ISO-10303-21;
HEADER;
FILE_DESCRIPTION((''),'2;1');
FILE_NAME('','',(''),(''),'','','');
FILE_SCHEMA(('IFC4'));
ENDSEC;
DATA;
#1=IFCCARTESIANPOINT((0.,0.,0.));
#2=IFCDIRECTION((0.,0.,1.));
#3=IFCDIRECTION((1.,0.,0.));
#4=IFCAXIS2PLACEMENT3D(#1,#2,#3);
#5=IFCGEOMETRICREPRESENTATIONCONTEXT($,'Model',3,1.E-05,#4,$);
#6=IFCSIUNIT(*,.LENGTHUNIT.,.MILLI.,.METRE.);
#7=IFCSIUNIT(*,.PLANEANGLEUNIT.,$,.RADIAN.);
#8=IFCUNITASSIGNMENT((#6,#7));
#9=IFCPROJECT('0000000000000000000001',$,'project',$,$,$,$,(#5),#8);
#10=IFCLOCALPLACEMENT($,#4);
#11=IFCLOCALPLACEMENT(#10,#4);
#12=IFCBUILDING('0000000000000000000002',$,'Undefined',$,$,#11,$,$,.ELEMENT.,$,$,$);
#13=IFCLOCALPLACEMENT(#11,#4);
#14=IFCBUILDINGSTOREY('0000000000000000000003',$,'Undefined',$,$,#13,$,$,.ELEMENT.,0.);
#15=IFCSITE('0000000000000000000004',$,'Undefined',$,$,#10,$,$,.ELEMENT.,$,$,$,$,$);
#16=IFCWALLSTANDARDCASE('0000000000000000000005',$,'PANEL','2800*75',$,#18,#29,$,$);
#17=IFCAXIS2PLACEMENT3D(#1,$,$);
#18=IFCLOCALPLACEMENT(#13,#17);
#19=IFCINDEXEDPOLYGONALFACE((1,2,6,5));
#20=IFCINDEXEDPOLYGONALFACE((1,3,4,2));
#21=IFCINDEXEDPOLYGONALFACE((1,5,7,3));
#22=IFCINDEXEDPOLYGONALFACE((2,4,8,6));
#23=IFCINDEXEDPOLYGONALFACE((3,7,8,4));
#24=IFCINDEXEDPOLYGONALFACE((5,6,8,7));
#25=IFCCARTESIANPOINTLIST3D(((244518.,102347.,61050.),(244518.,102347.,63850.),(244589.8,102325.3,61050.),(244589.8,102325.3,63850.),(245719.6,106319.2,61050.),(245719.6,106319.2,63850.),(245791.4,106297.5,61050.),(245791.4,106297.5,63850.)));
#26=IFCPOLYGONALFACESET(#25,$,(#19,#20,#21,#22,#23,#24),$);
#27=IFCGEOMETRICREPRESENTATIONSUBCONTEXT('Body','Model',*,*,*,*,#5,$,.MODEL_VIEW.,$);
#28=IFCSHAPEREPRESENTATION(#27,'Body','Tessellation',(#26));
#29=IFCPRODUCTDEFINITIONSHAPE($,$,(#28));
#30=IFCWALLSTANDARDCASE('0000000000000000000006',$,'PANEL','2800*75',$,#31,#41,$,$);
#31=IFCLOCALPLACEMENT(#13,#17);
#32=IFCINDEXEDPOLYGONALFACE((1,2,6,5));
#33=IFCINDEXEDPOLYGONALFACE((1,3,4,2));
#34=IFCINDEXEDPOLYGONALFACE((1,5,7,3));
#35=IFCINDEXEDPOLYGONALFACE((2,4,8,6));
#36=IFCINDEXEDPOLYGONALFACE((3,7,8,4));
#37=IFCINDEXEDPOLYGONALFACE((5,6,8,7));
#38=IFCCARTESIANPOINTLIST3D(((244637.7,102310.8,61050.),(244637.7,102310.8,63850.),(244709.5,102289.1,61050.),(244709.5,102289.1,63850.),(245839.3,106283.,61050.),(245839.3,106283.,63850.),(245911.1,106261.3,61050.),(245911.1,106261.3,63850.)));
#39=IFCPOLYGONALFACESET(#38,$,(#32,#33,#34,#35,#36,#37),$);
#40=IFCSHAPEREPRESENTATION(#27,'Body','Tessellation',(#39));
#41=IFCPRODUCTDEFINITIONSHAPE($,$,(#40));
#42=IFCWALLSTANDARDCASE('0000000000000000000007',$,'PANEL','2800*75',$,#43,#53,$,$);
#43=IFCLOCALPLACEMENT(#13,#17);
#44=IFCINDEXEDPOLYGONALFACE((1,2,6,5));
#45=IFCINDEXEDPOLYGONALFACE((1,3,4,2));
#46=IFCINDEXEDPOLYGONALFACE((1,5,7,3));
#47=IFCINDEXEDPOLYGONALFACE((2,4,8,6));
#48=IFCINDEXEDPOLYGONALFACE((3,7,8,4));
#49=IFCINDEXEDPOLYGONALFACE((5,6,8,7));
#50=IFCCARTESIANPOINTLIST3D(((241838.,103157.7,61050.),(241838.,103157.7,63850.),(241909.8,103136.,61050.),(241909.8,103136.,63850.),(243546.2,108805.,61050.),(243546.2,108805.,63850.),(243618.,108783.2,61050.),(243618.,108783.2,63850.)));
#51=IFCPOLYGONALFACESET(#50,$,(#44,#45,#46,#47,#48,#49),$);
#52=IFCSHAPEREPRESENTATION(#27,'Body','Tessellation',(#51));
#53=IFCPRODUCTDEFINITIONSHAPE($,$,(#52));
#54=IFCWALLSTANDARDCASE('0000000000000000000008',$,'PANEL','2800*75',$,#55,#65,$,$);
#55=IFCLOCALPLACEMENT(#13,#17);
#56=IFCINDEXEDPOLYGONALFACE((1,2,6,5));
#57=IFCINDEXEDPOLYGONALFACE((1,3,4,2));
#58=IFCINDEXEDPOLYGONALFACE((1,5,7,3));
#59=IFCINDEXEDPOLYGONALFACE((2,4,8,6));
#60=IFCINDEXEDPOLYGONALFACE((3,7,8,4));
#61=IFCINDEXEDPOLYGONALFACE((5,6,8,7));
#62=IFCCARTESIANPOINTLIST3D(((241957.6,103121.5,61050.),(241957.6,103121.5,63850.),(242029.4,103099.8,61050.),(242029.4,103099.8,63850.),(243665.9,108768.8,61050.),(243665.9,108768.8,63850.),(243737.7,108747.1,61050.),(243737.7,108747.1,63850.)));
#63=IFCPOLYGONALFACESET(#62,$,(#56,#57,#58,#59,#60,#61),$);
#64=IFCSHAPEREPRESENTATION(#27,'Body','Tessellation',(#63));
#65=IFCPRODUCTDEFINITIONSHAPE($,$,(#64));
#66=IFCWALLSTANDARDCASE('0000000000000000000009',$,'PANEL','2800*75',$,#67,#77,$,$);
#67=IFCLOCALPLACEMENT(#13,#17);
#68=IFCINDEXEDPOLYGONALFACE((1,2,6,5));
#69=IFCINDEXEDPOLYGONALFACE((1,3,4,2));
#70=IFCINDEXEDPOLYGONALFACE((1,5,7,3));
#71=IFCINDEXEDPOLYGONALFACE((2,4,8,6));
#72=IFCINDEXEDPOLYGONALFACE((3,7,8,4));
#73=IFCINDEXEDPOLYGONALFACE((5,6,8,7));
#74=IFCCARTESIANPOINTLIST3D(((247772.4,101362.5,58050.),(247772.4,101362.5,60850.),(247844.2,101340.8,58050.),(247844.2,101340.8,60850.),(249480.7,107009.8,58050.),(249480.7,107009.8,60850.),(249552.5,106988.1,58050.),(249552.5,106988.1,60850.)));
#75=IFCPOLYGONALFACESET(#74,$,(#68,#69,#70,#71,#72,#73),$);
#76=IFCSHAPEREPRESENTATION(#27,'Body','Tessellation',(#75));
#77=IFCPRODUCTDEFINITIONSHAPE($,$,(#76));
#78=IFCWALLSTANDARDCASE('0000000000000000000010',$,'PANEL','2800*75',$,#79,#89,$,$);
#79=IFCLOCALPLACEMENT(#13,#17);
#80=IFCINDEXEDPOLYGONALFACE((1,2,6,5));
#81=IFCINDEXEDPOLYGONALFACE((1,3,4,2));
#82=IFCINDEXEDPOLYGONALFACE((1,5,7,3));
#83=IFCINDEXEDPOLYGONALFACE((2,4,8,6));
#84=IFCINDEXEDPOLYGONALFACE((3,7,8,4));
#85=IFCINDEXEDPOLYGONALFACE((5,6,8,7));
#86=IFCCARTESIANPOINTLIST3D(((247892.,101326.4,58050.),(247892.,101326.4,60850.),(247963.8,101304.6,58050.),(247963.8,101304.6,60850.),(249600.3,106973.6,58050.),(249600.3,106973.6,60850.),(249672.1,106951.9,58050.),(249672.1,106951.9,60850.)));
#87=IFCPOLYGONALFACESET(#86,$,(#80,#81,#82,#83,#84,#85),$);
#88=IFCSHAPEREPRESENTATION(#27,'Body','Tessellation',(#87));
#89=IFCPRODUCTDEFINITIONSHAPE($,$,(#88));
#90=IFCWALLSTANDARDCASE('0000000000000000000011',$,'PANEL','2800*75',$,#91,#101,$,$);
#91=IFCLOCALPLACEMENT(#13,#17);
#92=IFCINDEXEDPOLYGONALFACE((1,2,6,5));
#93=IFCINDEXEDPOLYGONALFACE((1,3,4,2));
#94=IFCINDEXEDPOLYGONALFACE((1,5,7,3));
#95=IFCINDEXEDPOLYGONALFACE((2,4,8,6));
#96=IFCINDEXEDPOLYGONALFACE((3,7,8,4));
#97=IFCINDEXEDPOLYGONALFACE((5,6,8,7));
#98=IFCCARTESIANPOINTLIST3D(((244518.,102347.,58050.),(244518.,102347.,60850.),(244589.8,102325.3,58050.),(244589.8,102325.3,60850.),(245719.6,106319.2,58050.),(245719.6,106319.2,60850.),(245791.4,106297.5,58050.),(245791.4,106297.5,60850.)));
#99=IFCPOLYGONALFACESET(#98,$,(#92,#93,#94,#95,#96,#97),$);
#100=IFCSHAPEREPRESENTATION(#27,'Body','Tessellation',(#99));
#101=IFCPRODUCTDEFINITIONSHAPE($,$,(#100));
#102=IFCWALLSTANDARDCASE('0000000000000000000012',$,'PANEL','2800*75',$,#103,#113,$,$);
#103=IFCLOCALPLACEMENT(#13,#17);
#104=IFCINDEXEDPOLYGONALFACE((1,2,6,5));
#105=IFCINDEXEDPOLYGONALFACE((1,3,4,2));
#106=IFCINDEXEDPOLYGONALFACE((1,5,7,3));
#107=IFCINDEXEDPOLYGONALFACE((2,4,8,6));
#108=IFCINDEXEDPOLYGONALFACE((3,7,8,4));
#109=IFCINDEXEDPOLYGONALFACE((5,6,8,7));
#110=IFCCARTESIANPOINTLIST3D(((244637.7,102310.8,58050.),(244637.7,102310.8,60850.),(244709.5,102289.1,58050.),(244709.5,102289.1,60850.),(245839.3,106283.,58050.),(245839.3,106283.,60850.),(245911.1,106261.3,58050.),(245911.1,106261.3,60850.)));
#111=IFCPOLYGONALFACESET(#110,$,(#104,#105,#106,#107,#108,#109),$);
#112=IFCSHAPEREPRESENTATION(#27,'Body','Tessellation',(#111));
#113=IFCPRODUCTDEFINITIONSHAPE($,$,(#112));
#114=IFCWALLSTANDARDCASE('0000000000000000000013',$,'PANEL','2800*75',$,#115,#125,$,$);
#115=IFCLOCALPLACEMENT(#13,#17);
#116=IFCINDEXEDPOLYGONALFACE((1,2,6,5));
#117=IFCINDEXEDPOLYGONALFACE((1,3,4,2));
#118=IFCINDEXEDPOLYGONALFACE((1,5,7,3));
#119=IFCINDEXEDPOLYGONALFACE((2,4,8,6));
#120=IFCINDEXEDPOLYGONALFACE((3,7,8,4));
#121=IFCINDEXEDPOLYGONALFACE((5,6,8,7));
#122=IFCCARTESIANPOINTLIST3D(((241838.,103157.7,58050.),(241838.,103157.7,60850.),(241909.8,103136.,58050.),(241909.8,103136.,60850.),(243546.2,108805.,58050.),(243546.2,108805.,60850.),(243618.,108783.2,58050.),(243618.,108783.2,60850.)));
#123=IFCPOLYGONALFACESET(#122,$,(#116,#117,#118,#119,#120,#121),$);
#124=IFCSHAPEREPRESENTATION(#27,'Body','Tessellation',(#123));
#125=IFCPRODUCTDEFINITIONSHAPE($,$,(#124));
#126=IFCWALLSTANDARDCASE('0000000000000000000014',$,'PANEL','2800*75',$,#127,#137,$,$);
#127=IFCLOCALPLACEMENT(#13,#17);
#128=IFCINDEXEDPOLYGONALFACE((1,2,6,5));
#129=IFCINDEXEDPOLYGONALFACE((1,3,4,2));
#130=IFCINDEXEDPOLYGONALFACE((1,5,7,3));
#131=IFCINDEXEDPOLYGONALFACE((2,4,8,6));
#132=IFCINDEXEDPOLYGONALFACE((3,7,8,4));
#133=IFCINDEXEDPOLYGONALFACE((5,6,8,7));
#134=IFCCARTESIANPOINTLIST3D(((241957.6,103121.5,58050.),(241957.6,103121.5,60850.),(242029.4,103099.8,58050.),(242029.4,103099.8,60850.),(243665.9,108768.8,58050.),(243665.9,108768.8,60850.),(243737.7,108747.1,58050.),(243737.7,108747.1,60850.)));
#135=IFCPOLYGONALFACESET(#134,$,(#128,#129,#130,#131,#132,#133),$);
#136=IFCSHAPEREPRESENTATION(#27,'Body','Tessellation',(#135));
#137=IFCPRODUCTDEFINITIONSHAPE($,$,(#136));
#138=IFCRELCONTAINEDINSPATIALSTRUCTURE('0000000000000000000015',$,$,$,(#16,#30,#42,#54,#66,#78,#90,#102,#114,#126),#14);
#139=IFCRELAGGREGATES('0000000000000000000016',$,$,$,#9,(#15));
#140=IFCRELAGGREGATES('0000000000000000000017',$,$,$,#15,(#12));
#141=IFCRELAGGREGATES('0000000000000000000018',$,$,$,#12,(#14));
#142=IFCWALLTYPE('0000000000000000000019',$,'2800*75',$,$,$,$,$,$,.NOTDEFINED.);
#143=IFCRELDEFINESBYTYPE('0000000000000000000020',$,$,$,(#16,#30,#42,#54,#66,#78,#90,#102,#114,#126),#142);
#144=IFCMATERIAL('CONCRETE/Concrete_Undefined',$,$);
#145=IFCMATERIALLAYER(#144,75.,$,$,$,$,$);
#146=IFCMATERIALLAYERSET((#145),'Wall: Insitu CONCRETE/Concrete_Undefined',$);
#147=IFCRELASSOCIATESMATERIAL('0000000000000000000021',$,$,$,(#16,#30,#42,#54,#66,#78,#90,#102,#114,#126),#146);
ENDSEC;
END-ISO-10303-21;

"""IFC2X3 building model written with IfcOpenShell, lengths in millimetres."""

from ifc_helpers import new_model, si_unit, frame, frame_2d, origin_with_axes, place, context, subcontext, project, spatial, rectangle, extrude, material, layer, layer_set, layer_usage, type_object, element, save


model = new_model("IFC2X3")

# Units and contexts
model_context = context("Model", 3, precision=1e-05, world=origin_with_axes())
body_context = subcontext(model_context, "Body", "Model", "MODEL_VIEW")
ifc_project = project(units=[si_unit("LENGTHUNIT", "METRE", prefix="MILLI"), si_unit("PLANEANGLEUNIT", "RADIAN")], contexts=[model_context])

# Site, building, storey
site_placement = place(None, origin_with_axes())
site = spatial("IfcSite", under=ifc_project, at=site_placement, Name="Undefined", CompositionType="ELEMENT")
building_placement = place(site_placement, origin_with_axes())
building = spatial("IfcBuilding", under=site, at=building_placement, Name="Undefined", CompositionType="ELEMENT")
storey_placement = place(building_placement, origin_with_axes())
storey = spatial("IfcBuildingStorey", under=building, at=storey_placement, Name="Undefined", CompositionType="ELEMENT", Elevation=0.0)

# Shared definitions
ifc_material_1 = material(Name="CONCRETE/Concrete_Undefined")

# Walls
ifc_layer_1 = layer(ifc_material_1, 75.0)
ifc_layer_set_1 = layer_set([ifc_layer_1], Name="Wall: Insitu CONCRETE/Concrete_Undefined")
ifc_layer_usage_1 = layer_usage(ifc_layer_set_1, "AXIS2", "POSITIVE", -37.5)
wall_type_1 = type_object("IfcWallType", Name="2800*75", PredefinedType="NOTDEFINED")
wall_1_placement = place(storey_placement, frame((244553.9, 102336.1, 61050.0), z_axis=(0.0, 0.0, 1.0), x_axis=(0.289539, 0.957166, 0.0)))
element("IfcWallStandardCase", 1, at=wall_1_placement, inside=storey, type_object=wall_type_1, material=ifc_layer_usage_1, Name="PANEL", Description="2800*75", context=body_context, shape_type="SweptSolid", body=[
    extrude(rectangle(XDim=4150.0, YDim=75.0, at=frame_2d((0.0, 2075.0), x_axis=(0.0, -1.0))), frame((0.0, 0.0, 0.0), z_axis=(0.0, 0.0, 1.0), x_axis=(0.0, -1.0, 0.0)), (0.0, 0.0, 1.0), 2800.0),
])
ifc_layer_usage_2 = layer_usage(ifc_layer_set_1, "AXIS2", "POSITIVE", -37.5)
wall_2_placement = place(storey_placement, frame((244673.6, 102299.9, 61050.0), z_axis=(0.0, 0.0, 1.0), x_axis=(0.289539, 0.957166, 0.0)))
element("IfcWallStandardCase", 2, at=wall_2_placement, inside=storey, type_object=wall_type_1, material=ifc_layer_usage_2, Name="PANEL", Description="2800*75", context=body_context, shape_type="SweptSolid", body=[
    extrude(rectangle(XDim=4150.0, YDim=75.0, at=frame_2d((0.0, 2075.0), x_axis=(0.0, -1.0))), frame((0.0, 0.0, 0.0), z_axis=(0.0, 0.0, 1.0), x_axis=(0.0, -1.0, 0.0)), (0.0, 0.0, 1.0), 2800.0),
])
ifc_layer_usage_3 = layer_usage(ifc_layer_set_1, "AXIS2", "POSITIVE", -37.5)
wall_3_placement = place(storey_placement, frame((241873.9, 103146.8, 61050.0), z_axis=(0.0, 0.0, 1.0), x_axis=(0.289538, 0.957166, 0.0)))
element("IfcWallStandardCase", 3, at=wall_3_placement, inside=storey, type_object=wall_type_1, material=ifc_layer_usage_3, Name="PANEL", Description="2800*75", context=body_context, shape_type="SweptSolid", body=[
    extrude(rectangle(XDim=5900.0, YDim=75.0, at=frame_2d((0.0, 2950.0), x_axis=(0.0, -1.0))), frame((0.0, 0.0, 0.0), z_axis=(0.0, 0.0, 1.0), x_axis=(0.0, -1.0, 0.0)), (0.0, 0.0, 1.0), 2800.0),
])
ifc_layer_usage_4 = layer_usage(ifc_layer_set_1, "AXIS2", "POSITIVE", -37.5)
wall_4_placement = place(storey_placement, frame((241993.5, 103110.6, 61050.0), z_axis=(0.0, 0.0, 1.0), x_axis=(0.289538, 0.957166, 0.0)))
element("IfcWallStandardCase", 4, at=wall_4_placement, inside=storey, type_object=wall_type_1, material=ifc_layer_usage_4, Name="PANEL", Description="2800*75", context=body_context, shape_type="SweptSolid", body=[
    extrude(rectangle(XDim=5900.0, YDim=75.0, at=frame_2d((0.0, 2950.0), x_axis=(0.0, -1.0))), frame((0.0, 0.0, 0.0), z_axis=(0.0, 0.0, 1.0), x_axis=(0.0, -1.0, 0.0)), (0.0, 0.0, 1.0), 2800.0),
])
ifc_layer_usage_5 = layer_usage(ifc_layer_set_1, "AXIS2", "POSITIVE", -37.5)
wall_5_placement = place(storey_placement, frame((247808.3, 101351.7, 58050.0), z_axis=(0.0, 0.0, 1.0), x_axis=(0.289538, 0.957166, 0.0)))
element("IfcWallStandardCase", 5, at=wall_5_placement, inside=storey, type_object=wall_type_1, material=ifc_layer_usage_5, Name="PANEL", Description="2800*75", context=body_context, shape_type="SweptSolid", body=[
    extrude(rectangle(XDim=5900.0, YDim=75.0, at=frame_2d((0.0, 2950.0), x_axis=(0.0, -1.0))), frame((0.0, 0.0, 0.0), z_axis=(0.0, 0.0, 1.0), x_axis=(0.0, -1.0, 0.0)), (0.0, 0.0, 1.0), 2800.0),
])
ifc_layer_usage_6 = layer_usage(ifc_layer_set_1, "AXIS2", "POSITIVE", -37.5)
wall_6_placement = place(storey_placement, frame((247927.9, 101315.5, 58050.0), z_axis=(0.0, 0.0, 1.0), x_axis=(0.289538, 0.957166, 0.0)))
element("IfcWallStandardCase", 6, at=wall_6_placement, inside=storey, type_object=wall_type_1, material=ifc_layer_usage_6, Name="PANEL", Description="2800*75", context=body_context, shape_type="SweptSolid", body=[
    extrude(rectangle(XDim=5900.0, YDim=75.0, at=frame_2d((0.0, 2950.0), x_axis=(0.0, -1.0))), frame((0.0, 0.0, 0.0), z_axis=(0.0, 0.0, 1.0), x_axis=(0.0, -1.0, 0.0)), (0.0, 0.0, 1.0), 2800.0),
])
ifc_layer_usage_7 = layer_usage(ifc_layer_set_1, "AXIS2", "POSITIVE", -37.5)
wall_7_placement = place(storey_placement, frame((244553.9, 102336.1, 58050.0), z_axis=(0.0, 0.0, 1.0), x_axis=(0.289539, 0.957166, 0.0)))
element("IfcWallStandardCase", 7, at=wall_7_placement, inside=storey, type_object=wall_type_1, material=ifc_layer_usage_7, Name="PANEL", Description="2800*75", context=body_context, shape_type="SweptSolid", body=[
    extrude(rectangle(XDim=4150.0, YDim=75.0, at=frame_2d((0.0, 2075.0), x_axis=(0.0, -1.0))), frame((0.0, 0.0, 0.0), z_axis=(0.0, 0.0, 1.0), x_axis=(0.0, -1.0, 0.0)), (0.0, 0.0, 1.0), 2800.0),
])
ifc_layer_usage_8 = layer_usage(ifc_layer_set_1, "AXIS2", "POSITIVE", -37.5)
wall_8_placement = place(storey_placement, frame((244673.6, 102299.9, 58050.0), z_axis=(0.0, 0.0, 1.0), x_axis=(0.289539, 0.957166, 0.0)))
element("IfcWallStandardCase", 8, at=wall_8_placement, inside=storey, type_object=wall_type_1, material=ifc_layer_usage_8, Name="PANEL", Description="2800*75", context=body_context, shape_type="SweptSolid", body=[
    extrude(rectangle(XDim=4150.0, YDim=75.0, at=frame_2d((0.0, 2075.0), x_axis=(0.0, -1.0))), frame((0.0, 0.0, 0.0), z_axis=(0.0, 0.0, 1.0), x_axis=(0.0, -1.0, 0.0)), (0.0, 0.0, 1.0), 2800.0),
])
ifc_layer_usage_9 = layer_usage(ifc_layer_set_1, "AXIS2", "POSITIVE", -37.5)
wall_9_placement = place(storey_placement, frame((241873.9, 103146.8, 58050.0), z_axis=(0.0, 0.0, 1.0), x_axis=(0.289538, 0.957166, 0.0)))
element("IfcWallStandardCase", 9, at=wall_9_placement, inside=storey, type_object=wall_type_1, material=ifc_layer_usage_9, Name="PANEL", Description="2800*75", context=body_context, shape_type="SweptSolid", body=[
    extrude(rectangle(XDim=5900.0, YDim=75.0, at=frame_2d((0.0, 2950.0), x_axis=(0.0, -1.0))), frame((0.0, 0.0, 0.0), z_axis=(0.0, 0.0, 1.0), x_axis=(0.0, -1.0, 0.0)), (0.0, 0.0, 1.0), 2800.0),
])
ifc_layer_usage_10 = layer_usage(ifc_layer_set_1, "AXIS2", "POSITIVE", -37.5)
wall_10_placement = place(storey_placement, frame((241993.5, 103110.6, 58050.0), z_axis=(0.0, 0.0, 1.0), x_axis=(0.289538, 0.957166, 0.0)))
element("IfcWallStandardCase", 10, at=wall_10_placement, inside=storey, type_object=wall_type_1, material=ifc_layer_usage_10, Name="PANEL", Description="2800*75", context=body_context, shape_type="SweptSolid", body=[
    extrude(rectangle(XDim=5900.0, YDim=75.0, at=frame_2d((0.0, 2950.0), x_axis=(0.0, -1.0))), frame((0.0, 0.0, 0.0), z_axis=(0.0, 0.0, 1.0), x_axis=(0.0, -1.0, 0.0)), (0.0, 0.0, 1.0), 2800.0),
])

save(model, "model.ifc")
